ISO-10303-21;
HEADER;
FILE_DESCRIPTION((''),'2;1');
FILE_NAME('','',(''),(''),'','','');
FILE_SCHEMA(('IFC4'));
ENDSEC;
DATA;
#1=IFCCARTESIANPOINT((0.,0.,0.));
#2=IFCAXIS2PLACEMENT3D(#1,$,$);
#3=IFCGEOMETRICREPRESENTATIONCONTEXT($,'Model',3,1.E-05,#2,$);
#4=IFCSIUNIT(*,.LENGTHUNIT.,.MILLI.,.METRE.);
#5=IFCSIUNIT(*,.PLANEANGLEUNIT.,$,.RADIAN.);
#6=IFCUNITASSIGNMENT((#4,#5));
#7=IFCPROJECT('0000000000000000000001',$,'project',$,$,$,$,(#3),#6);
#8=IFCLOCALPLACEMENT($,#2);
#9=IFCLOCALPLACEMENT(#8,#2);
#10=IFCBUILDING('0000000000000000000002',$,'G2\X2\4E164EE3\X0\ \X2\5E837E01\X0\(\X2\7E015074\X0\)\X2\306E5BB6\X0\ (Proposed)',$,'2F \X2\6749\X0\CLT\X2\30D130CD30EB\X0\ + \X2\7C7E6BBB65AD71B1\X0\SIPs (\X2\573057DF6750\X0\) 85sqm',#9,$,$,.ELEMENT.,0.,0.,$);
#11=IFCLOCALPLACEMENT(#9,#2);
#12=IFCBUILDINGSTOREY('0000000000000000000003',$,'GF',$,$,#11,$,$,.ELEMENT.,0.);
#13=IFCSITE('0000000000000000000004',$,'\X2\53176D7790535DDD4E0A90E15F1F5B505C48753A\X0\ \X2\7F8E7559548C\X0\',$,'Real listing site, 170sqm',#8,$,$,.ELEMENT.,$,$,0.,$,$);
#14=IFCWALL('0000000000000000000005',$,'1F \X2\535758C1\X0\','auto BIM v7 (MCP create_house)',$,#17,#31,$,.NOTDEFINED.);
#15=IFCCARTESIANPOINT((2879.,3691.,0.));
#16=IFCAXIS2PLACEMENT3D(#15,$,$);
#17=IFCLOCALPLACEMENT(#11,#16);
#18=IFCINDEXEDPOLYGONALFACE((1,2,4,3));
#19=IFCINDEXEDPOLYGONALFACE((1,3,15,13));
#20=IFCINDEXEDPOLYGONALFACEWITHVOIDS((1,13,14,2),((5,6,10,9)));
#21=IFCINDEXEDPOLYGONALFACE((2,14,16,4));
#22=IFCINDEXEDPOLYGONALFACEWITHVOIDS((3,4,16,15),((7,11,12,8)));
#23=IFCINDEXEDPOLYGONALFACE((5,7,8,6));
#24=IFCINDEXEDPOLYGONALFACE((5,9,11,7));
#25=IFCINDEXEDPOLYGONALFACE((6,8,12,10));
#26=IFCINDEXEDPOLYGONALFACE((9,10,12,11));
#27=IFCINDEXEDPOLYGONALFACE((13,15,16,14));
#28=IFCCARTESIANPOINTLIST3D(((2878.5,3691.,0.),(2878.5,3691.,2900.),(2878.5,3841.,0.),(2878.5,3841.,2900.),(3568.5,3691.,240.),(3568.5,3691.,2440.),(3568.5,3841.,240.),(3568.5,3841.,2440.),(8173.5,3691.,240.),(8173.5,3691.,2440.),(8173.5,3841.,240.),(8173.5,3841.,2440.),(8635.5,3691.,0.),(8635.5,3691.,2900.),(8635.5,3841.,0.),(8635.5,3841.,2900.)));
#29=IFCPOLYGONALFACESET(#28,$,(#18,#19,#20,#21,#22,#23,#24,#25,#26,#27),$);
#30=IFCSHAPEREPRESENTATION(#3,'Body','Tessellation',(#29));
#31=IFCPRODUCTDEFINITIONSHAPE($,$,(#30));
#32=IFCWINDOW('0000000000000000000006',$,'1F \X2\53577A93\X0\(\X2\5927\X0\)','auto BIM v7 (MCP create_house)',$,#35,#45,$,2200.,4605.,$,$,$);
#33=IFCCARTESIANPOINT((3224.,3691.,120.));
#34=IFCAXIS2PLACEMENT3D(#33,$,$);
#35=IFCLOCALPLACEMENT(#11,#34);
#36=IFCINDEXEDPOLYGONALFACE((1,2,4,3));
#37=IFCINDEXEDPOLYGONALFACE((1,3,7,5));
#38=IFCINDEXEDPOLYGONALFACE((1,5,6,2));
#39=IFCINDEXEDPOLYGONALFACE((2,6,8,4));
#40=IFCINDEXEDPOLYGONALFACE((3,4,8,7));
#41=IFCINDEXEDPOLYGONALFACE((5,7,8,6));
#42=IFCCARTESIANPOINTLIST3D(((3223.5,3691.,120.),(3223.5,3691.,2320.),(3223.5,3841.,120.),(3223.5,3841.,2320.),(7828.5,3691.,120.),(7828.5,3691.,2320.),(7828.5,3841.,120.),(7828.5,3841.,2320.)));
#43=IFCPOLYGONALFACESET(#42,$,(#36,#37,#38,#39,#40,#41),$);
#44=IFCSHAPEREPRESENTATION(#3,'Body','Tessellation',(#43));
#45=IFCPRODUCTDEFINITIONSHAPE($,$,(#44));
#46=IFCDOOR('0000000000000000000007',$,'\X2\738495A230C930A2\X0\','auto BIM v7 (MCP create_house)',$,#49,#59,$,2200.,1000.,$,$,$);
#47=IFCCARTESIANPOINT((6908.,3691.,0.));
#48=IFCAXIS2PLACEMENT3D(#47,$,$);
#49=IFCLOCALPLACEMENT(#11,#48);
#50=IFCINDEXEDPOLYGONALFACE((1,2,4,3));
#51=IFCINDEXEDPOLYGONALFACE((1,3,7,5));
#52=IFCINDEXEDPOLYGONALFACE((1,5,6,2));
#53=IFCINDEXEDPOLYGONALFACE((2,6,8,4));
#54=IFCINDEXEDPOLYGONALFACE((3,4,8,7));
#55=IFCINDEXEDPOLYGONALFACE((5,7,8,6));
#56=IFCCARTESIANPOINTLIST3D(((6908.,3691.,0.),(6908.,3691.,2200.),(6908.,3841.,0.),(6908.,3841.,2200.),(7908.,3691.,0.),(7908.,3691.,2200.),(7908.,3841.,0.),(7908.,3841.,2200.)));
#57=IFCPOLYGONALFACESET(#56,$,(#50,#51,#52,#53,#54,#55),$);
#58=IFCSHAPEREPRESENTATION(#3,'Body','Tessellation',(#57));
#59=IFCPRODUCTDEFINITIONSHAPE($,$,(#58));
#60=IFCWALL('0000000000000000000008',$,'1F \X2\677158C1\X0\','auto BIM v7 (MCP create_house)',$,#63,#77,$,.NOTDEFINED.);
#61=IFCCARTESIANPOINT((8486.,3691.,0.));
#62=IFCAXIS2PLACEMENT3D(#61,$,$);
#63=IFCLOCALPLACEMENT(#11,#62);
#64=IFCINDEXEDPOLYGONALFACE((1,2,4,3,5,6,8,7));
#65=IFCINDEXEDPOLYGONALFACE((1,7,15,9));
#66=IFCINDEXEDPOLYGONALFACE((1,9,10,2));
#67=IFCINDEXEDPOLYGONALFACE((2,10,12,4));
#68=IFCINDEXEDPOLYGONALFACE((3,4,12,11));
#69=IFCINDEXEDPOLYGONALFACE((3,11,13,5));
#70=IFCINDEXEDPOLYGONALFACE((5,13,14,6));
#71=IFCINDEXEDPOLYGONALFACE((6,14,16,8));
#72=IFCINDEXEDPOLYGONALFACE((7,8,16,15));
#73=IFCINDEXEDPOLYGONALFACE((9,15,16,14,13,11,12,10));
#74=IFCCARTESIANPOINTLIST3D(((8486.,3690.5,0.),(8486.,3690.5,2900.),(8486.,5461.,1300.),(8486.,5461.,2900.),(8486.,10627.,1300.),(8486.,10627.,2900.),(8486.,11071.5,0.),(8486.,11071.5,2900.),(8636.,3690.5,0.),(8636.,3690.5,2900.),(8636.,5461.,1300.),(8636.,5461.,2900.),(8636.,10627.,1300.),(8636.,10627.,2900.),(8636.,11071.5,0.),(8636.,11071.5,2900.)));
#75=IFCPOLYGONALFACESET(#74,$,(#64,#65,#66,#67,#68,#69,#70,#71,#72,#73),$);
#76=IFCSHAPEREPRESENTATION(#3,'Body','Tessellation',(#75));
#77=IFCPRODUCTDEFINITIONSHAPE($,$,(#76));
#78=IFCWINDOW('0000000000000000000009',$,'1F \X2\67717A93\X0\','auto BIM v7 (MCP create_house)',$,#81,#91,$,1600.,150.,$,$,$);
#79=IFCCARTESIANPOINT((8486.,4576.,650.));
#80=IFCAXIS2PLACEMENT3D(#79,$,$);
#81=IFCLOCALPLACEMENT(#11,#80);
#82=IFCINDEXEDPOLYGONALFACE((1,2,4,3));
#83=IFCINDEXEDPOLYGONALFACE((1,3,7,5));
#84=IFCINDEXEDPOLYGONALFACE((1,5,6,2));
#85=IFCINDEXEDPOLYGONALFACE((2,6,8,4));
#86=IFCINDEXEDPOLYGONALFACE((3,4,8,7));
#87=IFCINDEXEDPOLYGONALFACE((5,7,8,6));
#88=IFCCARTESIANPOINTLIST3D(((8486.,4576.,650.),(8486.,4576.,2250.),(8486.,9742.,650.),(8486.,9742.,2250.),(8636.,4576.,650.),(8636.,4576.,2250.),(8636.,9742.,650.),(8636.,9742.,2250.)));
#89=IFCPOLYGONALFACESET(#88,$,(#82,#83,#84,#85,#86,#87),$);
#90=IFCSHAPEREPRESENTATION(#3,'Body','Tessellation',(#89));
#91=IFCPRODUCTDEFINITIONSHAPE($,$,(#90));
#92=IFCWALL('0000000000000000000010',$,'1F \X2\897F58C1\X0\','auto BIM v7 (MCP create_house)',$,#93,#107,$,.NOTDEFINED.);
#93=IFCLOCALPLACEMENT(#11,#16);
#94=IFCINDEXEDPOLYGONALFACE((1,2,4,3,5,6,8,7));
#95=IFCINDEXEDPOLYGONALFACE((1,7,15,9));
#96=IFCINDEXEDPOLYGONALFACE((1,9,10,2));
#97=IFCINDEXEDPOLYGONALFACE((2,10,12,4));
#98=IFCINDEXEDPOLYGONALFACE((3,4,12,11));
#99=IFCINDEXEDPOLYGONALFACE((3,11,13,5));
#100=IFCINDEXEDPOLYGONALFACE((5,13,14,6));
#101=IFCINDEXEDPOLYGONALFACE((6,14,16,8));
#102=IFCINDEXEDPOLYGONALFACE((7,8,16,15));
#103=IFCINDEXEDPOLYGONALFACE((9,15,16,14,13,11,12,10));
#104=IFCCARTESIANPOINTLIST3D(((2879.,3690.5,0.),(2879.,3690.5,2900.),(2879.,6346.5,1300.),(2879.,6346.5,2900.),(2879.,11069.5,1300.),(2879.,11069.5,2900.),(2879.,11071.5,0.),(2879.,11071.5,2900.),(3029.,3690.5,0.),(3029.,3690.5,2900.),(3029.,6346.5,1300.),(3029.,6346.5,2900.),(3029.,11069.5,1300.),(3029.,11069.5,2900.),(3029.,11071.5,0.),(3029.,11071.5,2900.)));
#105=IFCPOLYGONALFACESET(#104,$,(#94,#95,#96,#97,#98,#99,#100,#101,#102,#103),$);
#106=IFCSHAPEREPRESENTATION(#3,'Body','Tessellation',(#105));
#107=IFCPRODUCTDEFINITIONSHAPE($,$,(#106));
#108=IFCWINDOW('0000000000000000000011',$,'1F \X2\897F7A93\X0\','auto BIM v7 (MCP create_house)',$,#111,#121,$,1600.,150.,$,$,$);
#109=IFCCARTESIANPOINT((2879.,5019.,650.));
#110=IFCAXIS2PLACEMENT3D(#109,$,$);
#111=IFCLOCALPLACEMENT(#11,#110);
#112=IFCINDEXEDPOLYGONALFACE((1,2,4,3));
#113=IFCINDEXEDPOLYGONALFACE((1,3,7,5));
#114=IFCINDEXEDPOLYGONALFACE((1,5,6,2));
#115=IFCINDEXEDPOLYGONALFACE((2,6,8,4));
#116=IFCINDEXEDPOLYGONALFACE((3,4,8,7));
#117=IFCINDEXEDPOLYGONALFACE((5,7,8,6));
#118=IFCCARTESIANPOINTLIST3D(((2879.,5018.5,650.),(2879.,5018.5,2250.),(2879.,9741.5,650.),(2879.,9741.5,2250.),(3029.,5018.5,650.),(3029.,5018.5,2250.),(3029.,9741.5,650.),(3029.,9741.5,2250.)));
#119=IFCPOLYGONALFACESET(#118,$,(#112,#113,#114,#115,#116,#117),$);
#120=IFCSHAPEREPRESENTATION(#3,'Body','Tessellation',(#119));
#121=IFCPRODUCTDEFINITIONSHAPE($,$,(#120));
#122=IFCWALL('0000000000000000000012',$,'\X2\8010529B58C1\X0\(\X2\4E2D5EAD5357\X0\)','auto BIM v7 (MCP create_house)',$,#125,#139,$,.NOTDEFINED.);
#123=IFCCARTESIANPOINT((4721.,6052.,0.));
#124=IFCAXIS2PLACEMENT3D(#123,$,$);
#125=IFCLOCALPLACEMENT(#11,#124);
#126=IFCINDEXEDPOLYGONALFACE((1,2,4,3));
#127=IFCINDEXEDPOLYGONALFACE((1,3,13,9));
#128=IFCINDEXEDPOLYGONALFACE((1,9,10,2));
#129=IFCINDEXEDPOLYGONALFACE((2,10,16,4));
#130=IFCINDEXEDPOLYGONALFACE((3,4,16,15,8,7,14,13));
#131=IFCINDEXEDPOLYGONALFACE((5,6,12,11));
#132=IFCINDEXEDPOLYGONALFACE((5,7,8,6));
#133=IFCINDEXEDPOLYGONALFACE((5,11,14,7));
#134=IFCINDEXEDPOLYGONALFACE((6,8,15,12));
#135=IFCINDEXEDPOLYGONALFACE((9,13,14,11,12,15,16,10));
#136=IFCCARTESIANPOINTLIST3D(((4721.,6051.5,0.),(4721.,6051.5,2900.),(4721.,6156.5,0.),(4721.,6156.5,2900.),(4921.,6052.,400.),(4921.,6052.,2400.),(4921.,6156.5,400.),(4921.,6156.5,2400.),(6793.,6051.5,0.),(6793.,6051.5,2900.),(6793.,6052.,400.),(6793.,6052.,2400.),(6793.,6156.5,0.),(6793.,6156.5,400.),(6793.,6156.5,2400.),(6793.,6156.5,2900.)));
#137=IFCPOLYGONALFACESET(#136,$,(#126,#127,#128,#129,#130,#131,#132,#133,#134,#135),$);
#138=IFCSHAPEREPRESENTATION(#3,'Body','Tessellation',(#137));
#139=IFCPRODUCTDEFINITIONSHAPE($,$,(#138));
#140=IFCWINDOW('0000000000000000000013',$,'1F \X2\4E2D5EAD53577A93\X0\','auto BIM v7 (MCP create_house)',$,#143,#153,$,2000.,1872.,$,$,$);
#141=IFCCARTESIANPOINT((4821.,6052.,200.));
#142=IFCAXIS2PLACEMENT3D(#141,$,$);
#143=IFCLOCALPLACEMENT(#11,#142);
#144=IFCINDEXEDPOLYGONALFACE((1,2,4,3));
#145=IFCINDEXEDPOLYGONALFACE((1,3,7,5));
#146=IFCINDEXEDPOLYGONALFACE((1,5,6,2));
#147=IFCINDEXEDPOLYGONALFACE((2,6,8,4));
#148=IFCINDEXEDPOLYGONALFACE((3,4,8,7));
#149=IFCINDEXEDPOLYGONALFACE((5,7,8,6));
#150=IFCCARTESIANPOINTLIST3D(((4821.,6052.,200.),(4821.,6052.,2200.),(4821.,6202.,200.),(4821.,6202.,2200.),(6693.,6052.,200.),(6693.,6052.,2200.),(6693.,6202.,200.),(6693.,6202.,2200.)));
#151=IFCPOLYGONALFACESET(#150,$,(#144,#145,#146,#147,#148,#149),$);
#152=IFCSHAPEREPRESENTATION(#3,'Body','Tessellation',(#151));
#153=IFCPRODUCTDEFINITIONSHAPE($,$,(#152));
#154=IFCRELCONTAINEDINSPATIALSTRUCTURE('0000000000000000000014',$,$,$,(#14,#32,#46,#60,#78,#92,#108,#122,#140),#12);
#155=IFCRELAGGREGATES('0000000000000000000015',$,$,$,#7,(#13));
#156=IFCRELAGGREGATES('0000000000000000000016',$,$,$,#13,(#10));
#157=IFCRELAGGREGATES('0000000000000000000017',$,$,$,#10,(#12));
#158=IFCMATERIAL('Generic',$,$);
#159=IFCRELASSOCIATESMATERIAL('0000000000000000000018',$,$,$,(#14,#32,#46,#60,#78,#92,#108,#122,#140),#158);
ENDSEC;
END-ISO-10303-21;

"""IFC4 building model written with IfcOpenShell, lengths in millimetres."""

from ifc_helpers import new_model, si_unit, frame, frame_2d, origin, place, context, project, spatial, rectangle, extrude, material, element, fill, save


model = new_model("IFC4")

# Units and contexts
model_context = context("Model", 3, precision=1e-05, world=origin())
ifc_project = project(units=[si_unit("LENGTHUNIT", "METRE", prefix="MILLI"), si_unit("PLANEANGLEUNIT", "RADIAN")], contexts=[model_context])

# Site, building, storey
site_placement = place(None, origin())
site = spatial("IfcSite", under=ifc_project, at=site_placement, Name="北海道川上郡弟子屈町 美留和", ObjectType="Real listing site, 170sqm", CompositionType="ELEMENT", RefElevation=0.0)
building_placement = place(site_placement, origin())
building = spatial("IfcBuilding", under=site, at=building_placement, Name="G2世代 広縁(縁側)の家 (Proposed)", ObjectType="2F 杉CLTパネル + 籾殻断熱SIPs (地域材) 85sqm", CompositionType="ELEMENT", ElevationOfRefHeight=0.0, ElevationOfTerrain=0.0)
storey_placement = place(building_placement, origin())
storey = spatial("IfcBuildingStorey", under=building, at=storey_placement, Name="GF", CompositionType="ELEMENT", Elevation=0.0)

# Shared definitions
ifc_material = material(Name="Generic")

# Wall, openings, window, door
wall_1_placement = place(storey_placement, frame((2879.0, 3691.0, 0.0)))
wall_1 = element("IfcWall", 1, at=wall_1_placement, inside=storey, material=ifc_material, Name="1F 南壁", Description="auto BIM v7 (MCP create_house)", PredefinedType="NOTDEFINED", context=model_context, shape_type="SweptSolid", body=[
    extrude(rectangle(XDim=5757.0, YDim=150.0, at=frame_2d((2878.0, 75.0))), frame((2879.0, 3691.0, 0.0)), (0.0, 0.0, 1.0), 2900.0),
])
opening_1_placement = place(storey_placement, frame((3224.0, 3691.0, 120.0)))
opening_1 = element("IfcOpeningElement", 2, at=opening_1_placement, cuts=wall_1, PredefinedType="NOTDEFINED", context=model_context, shape_type="SweptSolid", body=[
    extrude(rectangle(XDim=4605.0, YDim=150.0, at=frame_2d((2302.0, 75.0))), frame((3224.0, 3691.0, 120.0)), (0.0, 0.0, 1.0), 2200.0),
])
opening_2_placement = place(storey_placement, frame((6908.0, 3691.0, 0.0)))
opening_2 = element("IfcOpeningElement", 3, at=opening_2_placement, cuts=wall_1, PredefinedType="NOTDEFINED", context=model_context, shape_type="SweptSolid", body=[
    extrude(rectangle(XDim=1000.0, YDim=150.0, at=frame_2d((500.0, 75.0))), frame((6908.0, 3691.0, 0.0)), (0.0, 0.0, 1.0), 2200.0),
])
window_1_placement = place(storey_placement, frame((3224.0, 3691.0, 120.0)))
window_1 = element("IfcWindow", 4, at=window_1_placement, inside=storey, material=ifc_material, Name="1F 南窓(大)", Description="auto BIM v7 (MCP create_house)", OverallHeight=2200.0, OverallWidth=4605.0, context=model_context, shape_type="SweptSolid", body=[
    extrude(rectangle(XDim=4605.0, YDim=150.0, at=frame_2d((2302.0, 75.0))), frame((3224.0, 3691.0, 120.0)), (0.0, 0.0, 1.0), 2200.0),
])
fill(opening_1, window_1)
door_placement = place(storey_placement, frame((6908.0, 3691.0, 0.0)))
door = element("IfcDoor", 5, at=door_placement, inside=storey, material=ifc_material, Name="玄関ドア", Description="auto BIM v7 (MCP create_house)", OverallHeight=2200.0, OverallWidth=1000.0, context=model_context, shape_type="SweptSolid", body=[
    extrude(rectangle(XDim=1000.0, YDim=150.0, at=frame_2d((500.0, 75.0))), frame((6908.0, 3691.0, 0.0)), (0.0, 0.0, 1.0), 2200.0),
])
fill(opening_2, door)

# Walls, openings, windows
wall_2_placement = place(storey_placement, frame((8486.0, 3691.0, 0.0)))
wall_2 = element("IfcWall", 6, at=wall_2_placement, inside=storey, material=ifc_material, Name="1F 東壁", Description="auto BIM v7 (MCP create_house)", PredefinedType="NOTDEFINED", context=model_context, shape_type="SweptSolid", body=[
    extrude(rectangle(XDim=150.0, YDim=7381.0, at=frame_2d((75.0, 3690.0))), frame((8486.0, 3691.0, 0.0)), (0.0, 0.0, 1.0), 2900.0),
])
opening_3_placement = place(storey_placement, frame((8486.0, 4576.0, 650.0)))
opening_3 = element("IfcOpeningElement", 7, at=opening_3_placement, cuts=wall_2, PredefinedType="NOTDEFINED", context=model_context, shape_type="SweptSolid", body=[
    extrude(rectangle(XDim=150.0, YDim=5166.0, at=frame_2d((75.0, 2583.0))), frame((8486.0, 4576.0, 650.0)), (0.0, 0.0, 1.0), 1600.0),
])
window_2_placement = place(storey_placement, frame((8486.0, 4576.0, 650.0)))
window_2 = element("IfcWindow", 8, at=window_2_placement, inside=storey, material=ifc_material, Name="1F 東窓", Description="auto BIM v7 (MCP create_house)", OverallHeight=1600.0, OverallWidth=150.0, context=model_context, shape_type="SweptSolid", body=[
    extrude(rectangle(XDim=150.0, YDim=5166.0, at=frame_2d((75.0, 2583.0))), frame((8486.0, 4576.0, 650.0)), (0.0, 0.0, 1.0), 1600.0),
])
fill(opening_3, window_2)
wall_3_placement = place(storey_placement, frame((2879.0, 3691.0, 0.0)))
wall_3 = element("IfcWall", 9, at=wall_3_placement, inside=storey, material=ifc_material, Name="1F 西壁", Description="auto BIM v7 (MCP create_house)", PredefinedType="NOTDEFINED", context=model_context, shape_type="SweptSolid", body=[
    extrude(rectangle(XDim=150.0, YDim=7381.0, at=frame_2d((75.0, 3690.0))), frame((2879.0, 3691.0, 0.0)), (0.0, 0.0, 1.0), 2900.0),
])
opening_4_placement = place(storey_placement, frame((2879.0, 5019.0, 650.0)))
opening_4 = element("IfcOpeningElement", 10, at=opening_4_placement, cuts=wall_3, PredefinedType="NOTDEFINED", context=model_context, shape_type="SweptSolid", body=[
    extrude(rectangle(XDim=150.0, YDim=4723.0, at=frame_2d((75.0, 2361.0))), frame((2879.0, 5019.0, 650.0)), (0.0, 0.0, 1.0), 1600.0),
])
window_3_placement = place(storey_placement, frame((2879.0, 5019.0, 650.0)))
window_3 = element("IfcWindow", 11, at=window_3_placement, inside=storey, material=ifc_material, Name="1F 西窓", Description="auto BIM v7 (MCP create_house)", OverallHeight=1600.0, OverallWidth=150.0, context=model_context, shape_type="SweptSolid", body=[
    extrude(rectangle(XDim=150.0, YDim=4723.0, at=frame_2d((75.0, 2361.0))), frame((2879.0, 5019.0, 650.0)), (0.0, 0.0, 1.0), 1600.0),
])
fill(opening_4, window_3)
wall_4_placement = place(storey_placement, frame((4721.0, 6052.0, 0.0)))
wall_4 = element("IfcWall", 12, at=wall_4_placement, inside=storey, material=ifc_material, Name="耐力壁(中庭南)", Description="auto BIM v7 (MCP create_house)", PredefinedType="NOTDEFINED", context=model_context, shape_type="SweptSolid", body=[
    extrude(rectangle(XDim=2072.0, YDim=105.0, at=frame_2d((1036.0, 52.0))), frame((4721.0, 6052.0, 0.0)), (0.0, 0.0, 1.0), 2900.0),
])
opening_5_placement = place(storey_placement, frame((4821.0, 6052.0, 200.0)))
opening_5 = element("IfcOpeningElement", 13, at=opening_5_placement, cuts=wall_4, PredefinedType="NOTDEFINED", context=model_context, shape_type="SweptSolid", body=[
    extrude(rectangle(XDim=1872.0, YDim=150.0, at=frame_2d((936.0, 75.0))), frame((4821.0, 6052.0, 200.0)), (0.0, 0.0, 1.0), 2000.0),
])
window_4_placement = place(storey_placement, frame((4821.0, 6052.0, 200.0)))
window_4 = element("IfcWindow", 14, at=window_4_placement, inside=storey, material=ifc_material, Name="1F 中庭南窓", Description="auto BIM v7 (MCP create_house)", OverallHeight=2000.0, OverallWidth=1872.0, context=model_context, shape_type="SweptSolid", body=[
    extrude(rectangle(XDim=1872.0, YDim=150.0, at=frame_2d((936.0, 75.0))), frame((4821.0, 6052.0, 200.0)), (0.0, 0.0, 1.0), 2000.0),
])
fill(opening_5, window_4)

save(model, "model.ifc")
